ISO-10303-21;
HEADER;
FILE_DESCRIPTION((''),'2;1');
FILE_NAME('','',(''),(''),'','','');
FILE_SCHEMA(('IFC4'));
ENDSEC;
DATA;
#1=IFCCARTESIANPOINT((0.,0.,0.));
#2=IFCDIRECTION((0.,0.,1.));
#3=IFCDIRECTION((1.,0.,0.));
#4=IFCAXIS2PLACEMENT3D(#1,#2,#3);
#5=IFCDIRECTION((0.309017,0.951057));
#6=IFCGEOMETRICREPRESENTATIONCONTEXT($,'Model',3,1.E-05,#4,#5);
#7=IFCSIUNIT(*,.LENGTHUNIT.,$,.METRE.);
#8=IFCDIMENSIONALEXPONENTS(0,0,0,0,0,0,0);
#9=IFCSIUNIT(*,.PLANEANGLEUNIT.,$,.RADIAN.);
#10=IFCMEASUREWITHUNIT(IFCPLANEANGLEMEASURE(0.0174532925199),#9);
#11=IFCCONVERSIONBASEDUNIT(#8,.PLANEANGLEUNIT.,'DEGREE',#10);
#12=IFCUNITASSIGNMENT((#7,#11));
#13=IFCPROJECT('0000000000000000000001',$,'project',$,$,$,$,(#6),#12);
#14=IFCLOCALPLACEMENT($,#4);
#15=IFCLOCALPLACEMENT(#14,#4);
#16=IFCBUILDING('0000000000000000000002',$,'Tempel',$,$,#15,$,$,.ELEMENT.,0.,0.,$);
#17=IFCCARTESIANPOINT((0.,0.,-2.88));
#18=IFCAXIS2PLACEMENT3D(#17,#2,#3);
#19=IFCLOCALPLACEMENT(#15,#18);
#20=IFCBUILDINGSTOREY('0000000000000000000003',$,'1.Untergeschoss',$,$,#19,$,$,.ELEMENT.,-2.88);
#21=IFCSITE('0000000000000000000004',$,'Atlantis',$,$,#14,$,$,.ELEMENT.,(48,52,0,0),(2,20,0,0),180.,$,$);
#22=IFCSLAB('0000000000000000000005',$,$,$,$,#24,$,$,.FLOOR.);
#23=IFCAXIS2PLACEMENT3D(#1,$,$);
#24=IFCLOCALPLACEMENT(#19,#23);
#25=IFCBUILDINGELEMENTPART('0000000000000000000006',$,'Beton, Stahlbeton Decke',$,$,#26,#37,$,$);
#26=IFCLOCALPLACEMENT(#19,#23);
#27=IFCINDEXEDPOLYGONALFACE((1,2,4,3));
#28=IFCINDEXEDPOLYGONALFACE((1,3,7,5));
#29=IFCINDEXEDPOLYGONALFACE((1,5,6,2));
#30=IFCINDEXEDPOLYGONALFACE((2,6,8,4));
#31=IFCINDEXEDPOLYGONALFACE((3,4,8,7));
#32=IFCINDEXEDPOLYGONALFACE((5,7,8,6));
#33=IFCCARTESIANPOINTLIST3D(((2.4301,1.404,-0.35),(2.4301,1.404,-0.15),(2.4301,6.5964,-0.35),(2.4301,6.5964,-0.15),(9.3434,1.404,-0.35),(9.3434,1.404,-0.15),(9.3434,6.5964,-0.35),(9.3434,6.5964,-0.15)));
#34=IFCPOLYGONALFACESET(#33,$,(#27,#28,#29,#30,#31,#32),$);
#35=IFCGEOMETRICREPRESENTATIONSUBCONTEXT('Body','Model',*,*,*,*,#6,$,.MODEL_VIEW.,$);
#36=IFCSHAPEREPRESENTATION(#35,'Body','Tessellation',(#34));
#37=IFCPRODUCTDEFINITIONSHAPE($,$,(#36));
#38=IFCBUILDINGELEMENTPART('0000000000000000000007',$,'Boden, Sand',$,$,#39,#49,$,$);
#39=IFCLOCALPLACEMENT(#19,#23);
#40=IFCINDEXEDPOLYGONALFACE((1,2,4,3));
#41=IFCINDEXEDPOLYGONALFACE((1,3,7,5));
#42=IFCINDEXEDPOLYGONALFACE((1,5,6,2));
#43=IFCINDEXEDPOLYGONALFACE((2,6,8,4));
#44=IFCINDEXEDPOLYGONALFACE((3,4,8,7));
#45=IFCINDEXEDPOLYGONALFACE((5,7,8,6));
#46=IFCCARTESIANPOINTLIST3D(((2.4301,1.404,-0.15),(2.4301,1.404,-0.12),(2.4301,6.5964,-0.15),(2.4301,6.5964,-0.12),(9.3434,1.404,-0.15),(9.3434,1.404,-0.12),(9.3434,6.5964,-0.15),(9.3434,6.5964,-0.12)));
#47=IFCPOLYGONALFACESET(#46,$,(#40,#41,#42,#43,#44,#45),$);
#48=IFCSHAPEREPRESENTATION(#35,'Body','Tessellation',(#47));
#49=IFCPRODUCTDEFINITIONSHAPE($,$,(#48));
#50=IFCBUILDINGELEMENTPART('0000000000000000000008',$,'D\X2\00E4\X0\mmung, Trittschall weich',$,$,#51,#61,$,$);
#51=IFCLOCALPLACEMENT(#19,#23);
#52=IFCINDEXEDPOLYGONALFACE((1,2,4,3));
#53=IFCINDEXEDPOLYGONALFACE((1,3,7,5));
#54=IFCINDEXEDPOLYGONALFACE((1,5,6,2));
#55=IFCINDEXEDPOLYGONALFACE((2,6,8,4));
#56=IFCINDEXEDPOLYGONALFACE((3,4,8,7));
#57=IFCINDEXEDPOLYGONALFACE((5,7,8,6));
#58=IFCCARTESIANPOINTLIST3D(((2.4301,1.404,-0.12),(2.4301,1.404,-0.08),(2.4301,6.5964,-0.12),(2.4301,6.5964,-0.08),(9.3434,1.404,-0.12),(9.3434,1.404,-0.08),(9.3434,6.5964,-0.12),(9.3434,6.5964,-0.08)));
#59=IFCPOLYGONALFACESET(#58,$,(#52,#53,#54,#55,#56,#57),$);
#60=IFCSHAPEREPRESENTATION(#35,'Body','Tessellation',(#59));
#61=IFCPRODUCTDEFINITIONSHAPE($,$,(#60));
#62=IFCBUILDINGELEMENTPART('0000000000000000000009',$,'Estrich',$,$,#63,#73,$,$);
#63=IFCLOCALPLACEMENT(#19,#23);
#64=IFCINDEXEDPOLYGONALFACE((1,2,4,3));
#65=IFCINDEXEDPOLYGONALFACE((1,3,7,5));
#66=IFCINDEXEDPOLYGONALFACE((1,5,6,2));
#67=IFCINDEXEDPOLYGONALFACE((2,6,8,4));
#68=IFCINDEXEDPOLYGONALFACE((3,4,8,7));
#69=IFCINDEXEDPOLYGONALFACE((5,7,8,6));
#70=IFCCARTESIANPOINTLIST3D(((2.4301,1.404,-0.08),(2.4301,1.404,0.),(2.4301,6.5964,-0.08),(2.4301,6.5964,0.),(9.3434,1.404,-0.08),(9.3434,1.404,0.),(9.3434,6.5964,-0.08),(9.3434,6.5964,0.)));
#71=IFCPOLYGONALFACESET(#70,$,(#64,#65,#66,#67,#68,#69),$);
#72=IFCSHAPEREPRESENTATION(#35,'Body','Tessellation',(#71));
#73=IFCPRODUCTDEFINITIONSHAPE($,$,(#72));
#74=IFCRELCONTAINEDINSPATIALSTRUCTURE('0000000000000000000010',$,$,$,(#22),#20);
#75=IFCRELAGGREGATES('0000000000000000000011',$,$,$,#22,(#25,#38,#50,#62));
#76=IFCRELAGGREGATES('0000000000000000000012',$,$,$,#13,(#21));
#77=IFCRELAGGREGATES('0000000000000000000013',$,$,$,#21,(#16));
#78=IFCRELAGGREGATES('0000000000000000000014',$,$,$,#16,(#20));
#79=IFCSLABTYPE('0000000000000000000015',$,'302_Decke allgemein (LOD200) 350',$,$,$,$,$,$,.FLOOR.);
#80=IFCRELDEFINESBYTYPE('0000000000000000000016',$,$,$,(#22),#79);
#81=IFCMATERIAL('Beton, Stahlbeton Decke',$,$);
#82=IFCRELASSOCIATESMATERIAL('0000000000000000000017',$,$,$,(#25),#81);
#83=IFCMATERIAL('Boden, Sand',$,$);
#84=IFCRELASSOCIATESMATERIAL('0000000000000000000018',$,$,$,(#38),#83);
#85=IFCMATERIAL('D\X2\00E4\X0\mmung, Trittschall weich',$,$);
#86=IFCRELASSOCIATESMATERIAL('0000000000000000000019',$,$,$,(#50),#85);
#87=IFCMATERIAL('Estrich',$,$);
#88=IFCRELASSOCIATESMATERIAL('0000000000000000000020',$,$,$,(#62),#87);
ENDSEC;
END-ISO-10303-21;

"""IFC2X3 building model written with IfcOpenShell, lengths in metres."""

from ifc_helpers import new_model, entity, si_unit, converted_unit, direction, frame, origin_with_axes, place, context, subcontext, project, spatial, polyline, outline, extrude, material, type_object, element, aggregate, save


model = new_model("IFC2X3")

# Units and contexts
model_context = context("Model", 3, precision=1e-05, world=origin_with_axes(), true_north=direction((0.309017, 0.951057)))
body_context = subcontext(model_context, "Body", "Model", "MODEL_VIEW")
ifc_project = project(units=[si_unit("LENGTHUNIT", "METRE"), converted_unit("PLANEANGLEUNIT", "DEGREE", entity("IfcPlaneAngleMeasure", 0.0174532925199), si_unit("PLANEANGLEUNIT", "RADIAN"), dimensions=[0, 0, 0, 0, 0, 0, 0])], contexts=[model_context])

# Site, building, storey
site_placement = place(None, origin_with_axes())
site = spatial("IfcSite", under=ifc_project, at=site_placement, Name="Atlantis", CompositionType="ELEMENT", RefLatitude=(48, 52, 0, 0), RefLongitude=(2, 20, 0, 0), RefElevation=180.0)
building_placement = place(site_placement, origin_with_axes())
building = spatial("IfcBuilding", under=site, at=building_placement, Name="Tempel", CompositionType="ELEMENT", ElevationOfRefHeight=0.0, ElevationOfTerrain=0.0)
storey_placement = place(building_placement, frame((0.0, 0.0, -2.88), z_axis=(0.0, 0.0, 1.0), x_axis=(1.0, 0.0, 0.0)))
storey = spatial("IfcBuildingStorey", under=building, at=storey_placement, Name="1.Untergeschoss", CompositionType="ELEMENT", Elevation=-2.88)

# Slab, building element parts
slab_type = type_object("IfcSlabType", Name="302_Decke allgemein (LOD200) 350", PredefinedType="FLOOR")
slab_placement = place(storey_placement, frame((2.4301, 1.404, -0.15), z_axis=(0.0, 0.0, 1.0), x_axis=(1.0, 0.0, 0.0)))
slab = element("IfcSlab", 1, at=slab_placement, inside=storey, type_object=slab_type, PredefinedType="FLOOR")
ifc_material_1 = material(Name="Beton, Stahlbeton Decke")
building_element_part_1_placement = place(slab_placement, origin_with_axes())
building_element_part_1 = element("IfcBuildingElementPart", 2, at=building_element_part_1_placement, material=ifc_material_1, Name="Beton, Stahlbeton Decke", context=body_context, shape_type="SweptSolid", body=[
    extrude(outline(polyline([(0.0, 0.0), (6.9133, 0.0), (6.9133, 5.1924), (0.0, 5.1924), (0.0, 0.0)])), frame((0.0, 0.0, -0.2), z_axis=(0.0, 0.0, 1.0), x_axis=(1.0, 0.0, 0.0)), (0.0, 0.0, 1.0), 0.2),
])
ifc_material_2 = material(Name="Boden, Sand")
building_element_part_2_placement = place(slab_placement, origin_with_axes())
building_element_part_2 = element("IfcBuildingElementPart", 3, at=building_element_part_2_placement, material=ifc_material_2, Name="Boden, Sand", context=body_context, shape_type="SweptSolid", body=[
    extrude(outline(polyline([(0.0, 0.0), (6.9133, 0.0), (6.9133, 5.1924), (0.0, 5.1924), (0.0, 0.0)])), origin_with_axes(), (0.0, 0.0, 1.0), 0.03),
])
ifc_material_3 = material(Name="Dämmung, Trittschall weich")
building_element_part_3_placement = place(slab_placement, origin_with_axes())
building_element_part_3 = element("IfcBuildingElementPart", 4, at=building_element_part_3_placement, material=ifc_material_3, Name="Dämmung, Trittschall weich", context=body_context, shape_type="SweptSolid", body=[
    extrude(outline(polyline([(0.0, 0.0), (6.9133, 0.0), (6.9133, 5.1924), (0.0, 5.1924), (0.0, 0.0)])), frame((0.0, 0.0, 0.03), z_axis=(0.0, 0.0, 1.0), x_axis=(1.0, 0.0, 0.0)), (0.0, 0.0, 1.0), 0.04),
])
ifc_material_4 = material(Name="Estrich")
building_element_part_4_placement = place(slab_placement, origin_with_axes())
building_element_part_4 = element("IfcBuildingElementPart", 5, at=building_element_part_4_placement, material=ifc_material_4, Name="Estrich", context=body_context, shape_type="SweptSolid", body=[
    extrude(outline(polyline([(0.0, 0.0), (6.9133, 0.0), (6.9133, 5.1924), (0.0, 5.1924), (0.0, 0.0)])), frame((0.0, 0.0, 0.07), z_axis=(0.0, 0.0, 1.0), x_axis=(1.0, 0.0, 0.0)), (0.0, 0.0, 1.0), 0.08),
])
aggregate(slab, [building_element_part_1, building_element_part_2, building_element_part_3, building_element_part_4])

save(model, "model.ifc")
